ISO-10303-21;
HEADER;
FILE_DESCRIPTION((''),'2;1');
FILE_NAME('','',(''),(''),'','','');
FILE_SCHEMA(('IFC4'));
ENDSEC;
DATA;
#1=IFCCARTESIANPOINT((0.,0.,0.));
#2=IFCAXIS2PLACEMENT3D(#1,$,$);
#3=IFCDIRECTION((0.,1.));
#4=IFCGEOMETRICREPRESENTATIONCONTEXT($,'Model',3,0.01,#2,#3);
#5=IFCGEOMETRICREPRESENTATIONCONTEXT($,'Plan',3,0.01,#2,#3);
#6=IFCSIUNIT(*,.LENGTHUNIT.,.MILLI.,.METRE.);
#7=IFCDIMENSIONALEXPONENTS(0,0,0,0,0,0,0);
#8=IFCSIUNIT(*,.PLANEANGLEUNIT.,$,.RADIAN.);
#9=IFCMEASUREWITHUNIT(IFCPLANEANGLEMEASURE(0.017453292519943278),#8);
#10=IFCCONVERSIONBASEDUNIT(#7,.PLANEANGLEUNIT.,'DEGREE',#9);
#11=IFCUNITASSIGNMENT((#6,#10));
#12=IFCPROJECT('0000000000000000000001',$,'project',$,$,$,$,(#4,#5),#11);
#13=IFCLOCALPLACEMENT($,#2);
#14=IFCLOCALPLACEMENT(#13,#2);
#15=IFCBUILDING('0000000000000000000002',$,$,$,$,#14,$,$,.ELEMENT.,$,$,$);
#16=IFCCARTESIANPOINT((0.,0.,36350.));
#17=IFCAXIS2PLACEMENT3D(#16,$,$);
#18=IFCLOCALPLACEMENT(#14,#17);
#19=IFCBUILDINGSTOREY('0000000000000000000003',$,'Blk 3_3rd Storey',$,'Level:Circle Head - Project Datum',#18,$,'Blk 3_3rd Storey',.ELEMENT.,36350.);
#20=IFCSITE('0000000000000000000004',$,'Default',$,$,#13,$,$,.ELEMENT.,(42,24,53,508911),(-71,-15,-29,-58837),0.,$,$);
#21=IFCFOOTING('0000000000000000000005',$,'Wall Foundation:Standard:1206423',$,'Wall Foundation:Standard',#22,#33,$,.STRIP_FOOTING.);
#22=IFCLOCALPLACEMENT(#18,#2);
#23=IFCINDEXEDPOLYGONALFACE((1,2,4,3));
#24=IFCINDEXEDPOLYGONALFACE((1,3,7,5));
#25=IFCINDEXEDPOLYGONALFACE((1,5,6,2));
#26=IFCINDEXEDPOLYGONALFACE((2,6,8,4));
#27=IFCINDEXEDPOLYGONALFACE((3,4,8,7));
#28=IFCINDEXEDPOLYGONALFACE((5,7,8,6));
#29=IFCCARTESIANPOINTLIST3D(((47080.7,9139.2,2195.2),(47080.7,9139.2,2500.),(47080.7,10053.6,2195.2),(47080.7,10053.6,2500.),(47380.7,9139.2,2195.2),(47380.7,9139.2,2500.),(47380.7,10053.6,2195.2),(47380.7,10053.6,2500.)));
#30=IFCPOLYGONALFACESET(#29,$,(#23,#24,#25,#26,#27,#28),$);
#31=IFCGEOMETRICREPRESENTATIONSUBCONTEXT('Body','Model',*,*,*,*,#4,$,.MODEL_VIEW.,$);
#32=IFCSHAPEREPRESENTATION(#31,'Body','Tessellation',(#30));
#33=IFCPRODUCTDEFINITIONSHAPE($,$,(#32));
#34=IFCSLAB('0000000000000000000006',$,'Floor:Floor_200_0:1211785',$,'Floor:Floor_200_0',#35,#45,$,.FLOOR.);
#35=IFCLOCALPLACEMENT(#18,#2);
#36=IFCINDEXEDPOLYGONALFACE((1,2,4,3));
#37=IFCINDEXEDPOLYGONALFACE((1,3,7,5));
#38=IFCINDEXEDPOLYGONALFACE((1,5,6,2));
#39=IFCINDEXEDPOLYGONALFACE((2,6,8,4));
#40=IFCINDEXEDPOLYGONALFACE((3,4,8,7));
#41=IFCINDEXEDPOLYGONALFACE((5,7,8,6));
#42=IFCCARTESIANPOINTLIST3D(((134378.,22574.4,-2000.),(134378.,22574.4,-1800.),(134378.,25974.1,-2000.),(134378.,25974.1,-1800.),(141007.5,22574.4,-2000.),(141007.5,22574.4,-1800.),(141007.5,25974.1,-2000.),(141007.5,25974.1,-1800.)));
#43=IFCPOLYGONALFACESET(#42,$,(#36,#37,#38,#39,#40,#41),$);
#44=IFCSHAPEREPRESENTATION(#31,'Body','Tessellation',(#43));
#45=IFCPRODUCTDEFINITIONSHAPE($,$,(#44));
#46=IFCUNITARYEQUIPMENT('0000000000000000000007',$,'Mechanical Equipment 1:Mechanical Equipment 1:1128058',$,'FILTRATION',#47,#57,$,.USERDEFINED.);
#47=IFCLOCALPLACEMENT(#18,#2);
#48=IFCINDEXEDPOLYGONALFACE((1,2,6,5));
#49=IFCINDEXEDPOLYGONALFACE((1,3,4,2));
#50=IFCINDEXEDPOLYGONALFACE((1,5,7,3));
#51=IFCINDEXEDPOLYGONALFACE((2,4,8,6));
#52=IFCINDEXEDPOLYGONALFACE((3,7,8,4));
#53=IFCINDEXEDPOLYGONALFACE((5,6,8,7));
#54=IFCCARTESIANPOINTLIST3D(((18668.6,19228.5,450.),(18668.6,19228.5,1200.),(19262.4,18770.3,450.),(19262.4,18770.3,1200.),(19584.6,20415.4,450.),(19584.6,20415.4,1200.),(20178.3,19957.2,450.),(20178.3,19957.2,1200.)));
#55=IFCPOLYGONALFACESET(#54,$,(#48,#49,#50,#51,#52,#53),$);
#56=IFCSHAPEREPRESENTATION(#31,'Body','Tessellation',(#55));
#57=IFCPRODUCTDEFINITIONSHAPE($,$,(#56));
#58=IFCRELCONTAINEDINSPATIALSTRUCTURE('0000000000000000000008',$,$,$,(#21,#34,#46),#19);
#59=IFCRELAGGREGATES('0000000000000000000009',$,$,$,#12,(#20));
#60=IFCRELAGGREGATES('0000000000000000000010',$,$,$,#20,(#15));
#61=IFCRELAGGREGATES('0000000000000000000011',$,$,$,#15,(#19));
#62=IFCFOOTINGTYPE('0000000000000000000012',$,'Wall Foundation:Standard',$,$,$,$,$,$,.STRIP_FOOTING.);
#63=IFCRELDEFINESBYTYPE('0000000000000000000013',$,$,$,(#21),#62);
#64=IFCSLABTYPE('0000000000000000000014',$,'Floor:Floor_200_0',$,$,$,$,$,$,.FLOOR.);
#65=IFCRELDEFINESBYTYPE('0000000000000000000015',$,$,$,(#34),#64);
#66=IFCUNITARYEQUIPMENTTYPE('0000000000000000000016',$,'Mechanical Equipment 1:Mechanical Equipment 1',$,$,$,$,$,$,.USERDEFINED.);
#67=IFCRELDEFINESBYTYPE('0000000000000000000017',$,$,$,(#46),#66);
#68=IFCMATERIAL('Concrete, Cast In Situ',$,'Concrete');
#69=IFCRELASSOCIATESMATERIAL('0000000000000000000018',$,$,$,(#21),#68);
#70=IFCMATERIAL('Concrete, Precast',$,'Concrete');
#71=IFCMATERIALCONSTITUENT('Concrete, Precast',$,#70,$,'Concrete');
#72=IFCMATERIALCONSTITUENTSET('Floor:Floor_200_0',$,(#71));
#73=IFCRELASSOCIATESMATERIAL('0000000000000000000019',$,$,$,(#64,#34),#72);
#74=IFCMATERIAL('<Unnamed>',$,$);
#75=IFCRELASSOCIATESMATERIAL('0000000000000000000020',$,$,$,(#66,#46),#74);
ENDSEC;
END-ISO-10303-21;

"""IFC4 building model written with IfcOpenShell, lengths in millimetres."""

from ifc_helpers import new_model, entity, si_unit, converted_unit, direction, frame, origin, place, context, subcontext, project, spatial, indexed_curve, outline, extrude, source, transform, mapped, material, constituent, constituent_set, type_object, type_shapes, element, save


model = new_model("IFC4")

# Units and contexts
model_context = context("Model", 3, precision=0.01, world=origin(), true_north=direction((0.0, 1.0)))
plan_context = context("Plan", 3, precision=0.01, world=origin(), true_north=direction((0.0, 1.0)))
body_context = subcontext(model_context, "Body", "Model", "MODEL_VIEW")
ifc_project = project(units=[si_unit("LENGTHUNIT", "METRE", prefix="MILLI"), converted_unit("PLANEANGLEUNIT", "DEGREE", entity("IfcPlaneAngleMeasure", 0.017453292519943278), si_unit("PLANEANGLEUNIT", "RADIAN"), dimensions=[0, 0, 0, 0, 0, 0, 0])], contexts=[model_context, plan_context])

# Site, building, storey
site_placement = place(None, origin())
site = spatial("IfcSite", under=ifc_project, at=site_placement, Name="Default", CompositionType="ELEMENT", RefLatitude=(42, 24, 53, 508911), RefLongitude=(-71, -15, -29, -58837), RefElevation=0.0)
building_placement = place(site_placement, origin())
building = spatial("IfcBuilding", under=site, at=building_placement, CompositionType="ELEMENT")
storey_placement = place(building_placement, frame((0.0, 0.0, 36350.0)))
storey = spatial("IfcBuildingStorey", under=building, at=storey_placement, Name="Blk 3_3rd Storey", ObjectType="Level:Circle Head - Project Datum", LongName="Blk 3_3rd Storey", CompositionType="ELEMENT", Elevation=36350.0)

# Footing
ifc_material_1 = material(Name="Concrete, Cast In Situ", Category="Concrete")
footing_type = type_object("IfcFootingType", Name="Wall Foundation:Standard", PredefinedType="STRIP_FOOTING")
footing_placement = place(storey_placement, origin())
element("IfcFooting", 1, at=footing_placement, inside=storey, type_object=footing_type, material=ifc_material_1, Name="Wall Foundation:Standard:1206423", ObjectType="Wall Foundation:Standard", PredefinedType="STRIP_FOOTING", context=body_context, shape_type="SweptSolid", body=[
    extrude(outline(indexed_curve([(-150.0, -457.2), (150.0, -457.2), (150.0, 457.2), (-150.0, 457.2), (-150.0, -457.2)], self_intersect=False)), frame((47230.7, 9596.4, 2195.2), z_axis=(0.0, 0.0, 1.0), x_axis=(-1.0, 0.0, 0.0)), (0.0, 0.0, 1.0), 304.8),
])

# Slab
ifc_material_2 = material(Name="Concrete, Precast", Category="Concrete")
ifc_constituent = constituent(ifc_material_2, Name="Concrete, Precast", Category="Concrete")
ifc_constituent_set = constituent_set(constituents=[ifc_constituent], Name="Floor:Floor_200_0")
slab_type = type_object("IfcSlabType", Name="Floor:Floor_200_0", PredefinedType="FLOOR", material=ifc_constituent_set)
slab_placement = place(storey_placement, origin())
element("IfcSlab", 2, at=slab_placement, inside=storey, type_object=slab_type, material=ifc_constituent_set, Name="Floor:Floor_200_0:1211785", ObjectType="Floor:Floor_200_0", PredefinedType="FLOOR", context=body_context, shape_type="SweptSolid", body=[
    extrude(outline(indexed_curve([(-1699.8, -3314.7), (1699.8, -3314.7), (1699.8, 3314.7), (-1699.8, 3314.7), (-1699.8, -3314.7)], self_intersect=False)), frame((137692.8, 24274.2, -1800.0), z_axis=(0.0, 0.0, -1.0), x_axis=(0.0, 1.0, 0.0)), (0.0, 0.0, 1.0), 200.0),
])

# Unitary equipment
ifc_material_3 = material(Name="<Unnamed>")
unitary_equipment_type = type_object("IfcUnitaryEquipmentType", Name="Mechanical Equipment 1:Mechanical Equipment 1", PredefinedType="USERDEFINED", material=ifc_material_3)
shared_shape = source(origin(), body_context, "Body", "SweptSolid", [
    extrude(outline(indexed_curve([(-749.6, -375.0), (749.6, -375.0), (749.6, 375.0), (-749.6, 375.0), (-749.6, -375.0)], self_intersect=False)), frame((19423.5, 19592.8, 36800.0), z_axis=(0.0, 0.0, 1.0), x_axis=(0.610948, 0.79167, 0.0)), (0.0, 0.0, 1.0), 750.0),
])
type_shapes(unitary_equipment_type, [shared_shape])
unitary_equipment_placement = place(storey_placement, frame((0.0, 0.0, -36350.0)))
element("IfcUnitaryEquipment", 3, at=unitary_equipment_placement, inside=storey, type_object=unitary_equipment_type, material=ifc_material_3, Name="Mechanical Equipment 1:Mechanical Equipment 1:1128058", ObjectType="FILTRATION", PredefinedType="USERDEFINED", context=body_context, shape_type="MappedRepresentation", body=[
    mapped(shared_shape, transform((0.0, 0.0, 0.0), scale=1.0)),
])

save(model, "model.ifc")
